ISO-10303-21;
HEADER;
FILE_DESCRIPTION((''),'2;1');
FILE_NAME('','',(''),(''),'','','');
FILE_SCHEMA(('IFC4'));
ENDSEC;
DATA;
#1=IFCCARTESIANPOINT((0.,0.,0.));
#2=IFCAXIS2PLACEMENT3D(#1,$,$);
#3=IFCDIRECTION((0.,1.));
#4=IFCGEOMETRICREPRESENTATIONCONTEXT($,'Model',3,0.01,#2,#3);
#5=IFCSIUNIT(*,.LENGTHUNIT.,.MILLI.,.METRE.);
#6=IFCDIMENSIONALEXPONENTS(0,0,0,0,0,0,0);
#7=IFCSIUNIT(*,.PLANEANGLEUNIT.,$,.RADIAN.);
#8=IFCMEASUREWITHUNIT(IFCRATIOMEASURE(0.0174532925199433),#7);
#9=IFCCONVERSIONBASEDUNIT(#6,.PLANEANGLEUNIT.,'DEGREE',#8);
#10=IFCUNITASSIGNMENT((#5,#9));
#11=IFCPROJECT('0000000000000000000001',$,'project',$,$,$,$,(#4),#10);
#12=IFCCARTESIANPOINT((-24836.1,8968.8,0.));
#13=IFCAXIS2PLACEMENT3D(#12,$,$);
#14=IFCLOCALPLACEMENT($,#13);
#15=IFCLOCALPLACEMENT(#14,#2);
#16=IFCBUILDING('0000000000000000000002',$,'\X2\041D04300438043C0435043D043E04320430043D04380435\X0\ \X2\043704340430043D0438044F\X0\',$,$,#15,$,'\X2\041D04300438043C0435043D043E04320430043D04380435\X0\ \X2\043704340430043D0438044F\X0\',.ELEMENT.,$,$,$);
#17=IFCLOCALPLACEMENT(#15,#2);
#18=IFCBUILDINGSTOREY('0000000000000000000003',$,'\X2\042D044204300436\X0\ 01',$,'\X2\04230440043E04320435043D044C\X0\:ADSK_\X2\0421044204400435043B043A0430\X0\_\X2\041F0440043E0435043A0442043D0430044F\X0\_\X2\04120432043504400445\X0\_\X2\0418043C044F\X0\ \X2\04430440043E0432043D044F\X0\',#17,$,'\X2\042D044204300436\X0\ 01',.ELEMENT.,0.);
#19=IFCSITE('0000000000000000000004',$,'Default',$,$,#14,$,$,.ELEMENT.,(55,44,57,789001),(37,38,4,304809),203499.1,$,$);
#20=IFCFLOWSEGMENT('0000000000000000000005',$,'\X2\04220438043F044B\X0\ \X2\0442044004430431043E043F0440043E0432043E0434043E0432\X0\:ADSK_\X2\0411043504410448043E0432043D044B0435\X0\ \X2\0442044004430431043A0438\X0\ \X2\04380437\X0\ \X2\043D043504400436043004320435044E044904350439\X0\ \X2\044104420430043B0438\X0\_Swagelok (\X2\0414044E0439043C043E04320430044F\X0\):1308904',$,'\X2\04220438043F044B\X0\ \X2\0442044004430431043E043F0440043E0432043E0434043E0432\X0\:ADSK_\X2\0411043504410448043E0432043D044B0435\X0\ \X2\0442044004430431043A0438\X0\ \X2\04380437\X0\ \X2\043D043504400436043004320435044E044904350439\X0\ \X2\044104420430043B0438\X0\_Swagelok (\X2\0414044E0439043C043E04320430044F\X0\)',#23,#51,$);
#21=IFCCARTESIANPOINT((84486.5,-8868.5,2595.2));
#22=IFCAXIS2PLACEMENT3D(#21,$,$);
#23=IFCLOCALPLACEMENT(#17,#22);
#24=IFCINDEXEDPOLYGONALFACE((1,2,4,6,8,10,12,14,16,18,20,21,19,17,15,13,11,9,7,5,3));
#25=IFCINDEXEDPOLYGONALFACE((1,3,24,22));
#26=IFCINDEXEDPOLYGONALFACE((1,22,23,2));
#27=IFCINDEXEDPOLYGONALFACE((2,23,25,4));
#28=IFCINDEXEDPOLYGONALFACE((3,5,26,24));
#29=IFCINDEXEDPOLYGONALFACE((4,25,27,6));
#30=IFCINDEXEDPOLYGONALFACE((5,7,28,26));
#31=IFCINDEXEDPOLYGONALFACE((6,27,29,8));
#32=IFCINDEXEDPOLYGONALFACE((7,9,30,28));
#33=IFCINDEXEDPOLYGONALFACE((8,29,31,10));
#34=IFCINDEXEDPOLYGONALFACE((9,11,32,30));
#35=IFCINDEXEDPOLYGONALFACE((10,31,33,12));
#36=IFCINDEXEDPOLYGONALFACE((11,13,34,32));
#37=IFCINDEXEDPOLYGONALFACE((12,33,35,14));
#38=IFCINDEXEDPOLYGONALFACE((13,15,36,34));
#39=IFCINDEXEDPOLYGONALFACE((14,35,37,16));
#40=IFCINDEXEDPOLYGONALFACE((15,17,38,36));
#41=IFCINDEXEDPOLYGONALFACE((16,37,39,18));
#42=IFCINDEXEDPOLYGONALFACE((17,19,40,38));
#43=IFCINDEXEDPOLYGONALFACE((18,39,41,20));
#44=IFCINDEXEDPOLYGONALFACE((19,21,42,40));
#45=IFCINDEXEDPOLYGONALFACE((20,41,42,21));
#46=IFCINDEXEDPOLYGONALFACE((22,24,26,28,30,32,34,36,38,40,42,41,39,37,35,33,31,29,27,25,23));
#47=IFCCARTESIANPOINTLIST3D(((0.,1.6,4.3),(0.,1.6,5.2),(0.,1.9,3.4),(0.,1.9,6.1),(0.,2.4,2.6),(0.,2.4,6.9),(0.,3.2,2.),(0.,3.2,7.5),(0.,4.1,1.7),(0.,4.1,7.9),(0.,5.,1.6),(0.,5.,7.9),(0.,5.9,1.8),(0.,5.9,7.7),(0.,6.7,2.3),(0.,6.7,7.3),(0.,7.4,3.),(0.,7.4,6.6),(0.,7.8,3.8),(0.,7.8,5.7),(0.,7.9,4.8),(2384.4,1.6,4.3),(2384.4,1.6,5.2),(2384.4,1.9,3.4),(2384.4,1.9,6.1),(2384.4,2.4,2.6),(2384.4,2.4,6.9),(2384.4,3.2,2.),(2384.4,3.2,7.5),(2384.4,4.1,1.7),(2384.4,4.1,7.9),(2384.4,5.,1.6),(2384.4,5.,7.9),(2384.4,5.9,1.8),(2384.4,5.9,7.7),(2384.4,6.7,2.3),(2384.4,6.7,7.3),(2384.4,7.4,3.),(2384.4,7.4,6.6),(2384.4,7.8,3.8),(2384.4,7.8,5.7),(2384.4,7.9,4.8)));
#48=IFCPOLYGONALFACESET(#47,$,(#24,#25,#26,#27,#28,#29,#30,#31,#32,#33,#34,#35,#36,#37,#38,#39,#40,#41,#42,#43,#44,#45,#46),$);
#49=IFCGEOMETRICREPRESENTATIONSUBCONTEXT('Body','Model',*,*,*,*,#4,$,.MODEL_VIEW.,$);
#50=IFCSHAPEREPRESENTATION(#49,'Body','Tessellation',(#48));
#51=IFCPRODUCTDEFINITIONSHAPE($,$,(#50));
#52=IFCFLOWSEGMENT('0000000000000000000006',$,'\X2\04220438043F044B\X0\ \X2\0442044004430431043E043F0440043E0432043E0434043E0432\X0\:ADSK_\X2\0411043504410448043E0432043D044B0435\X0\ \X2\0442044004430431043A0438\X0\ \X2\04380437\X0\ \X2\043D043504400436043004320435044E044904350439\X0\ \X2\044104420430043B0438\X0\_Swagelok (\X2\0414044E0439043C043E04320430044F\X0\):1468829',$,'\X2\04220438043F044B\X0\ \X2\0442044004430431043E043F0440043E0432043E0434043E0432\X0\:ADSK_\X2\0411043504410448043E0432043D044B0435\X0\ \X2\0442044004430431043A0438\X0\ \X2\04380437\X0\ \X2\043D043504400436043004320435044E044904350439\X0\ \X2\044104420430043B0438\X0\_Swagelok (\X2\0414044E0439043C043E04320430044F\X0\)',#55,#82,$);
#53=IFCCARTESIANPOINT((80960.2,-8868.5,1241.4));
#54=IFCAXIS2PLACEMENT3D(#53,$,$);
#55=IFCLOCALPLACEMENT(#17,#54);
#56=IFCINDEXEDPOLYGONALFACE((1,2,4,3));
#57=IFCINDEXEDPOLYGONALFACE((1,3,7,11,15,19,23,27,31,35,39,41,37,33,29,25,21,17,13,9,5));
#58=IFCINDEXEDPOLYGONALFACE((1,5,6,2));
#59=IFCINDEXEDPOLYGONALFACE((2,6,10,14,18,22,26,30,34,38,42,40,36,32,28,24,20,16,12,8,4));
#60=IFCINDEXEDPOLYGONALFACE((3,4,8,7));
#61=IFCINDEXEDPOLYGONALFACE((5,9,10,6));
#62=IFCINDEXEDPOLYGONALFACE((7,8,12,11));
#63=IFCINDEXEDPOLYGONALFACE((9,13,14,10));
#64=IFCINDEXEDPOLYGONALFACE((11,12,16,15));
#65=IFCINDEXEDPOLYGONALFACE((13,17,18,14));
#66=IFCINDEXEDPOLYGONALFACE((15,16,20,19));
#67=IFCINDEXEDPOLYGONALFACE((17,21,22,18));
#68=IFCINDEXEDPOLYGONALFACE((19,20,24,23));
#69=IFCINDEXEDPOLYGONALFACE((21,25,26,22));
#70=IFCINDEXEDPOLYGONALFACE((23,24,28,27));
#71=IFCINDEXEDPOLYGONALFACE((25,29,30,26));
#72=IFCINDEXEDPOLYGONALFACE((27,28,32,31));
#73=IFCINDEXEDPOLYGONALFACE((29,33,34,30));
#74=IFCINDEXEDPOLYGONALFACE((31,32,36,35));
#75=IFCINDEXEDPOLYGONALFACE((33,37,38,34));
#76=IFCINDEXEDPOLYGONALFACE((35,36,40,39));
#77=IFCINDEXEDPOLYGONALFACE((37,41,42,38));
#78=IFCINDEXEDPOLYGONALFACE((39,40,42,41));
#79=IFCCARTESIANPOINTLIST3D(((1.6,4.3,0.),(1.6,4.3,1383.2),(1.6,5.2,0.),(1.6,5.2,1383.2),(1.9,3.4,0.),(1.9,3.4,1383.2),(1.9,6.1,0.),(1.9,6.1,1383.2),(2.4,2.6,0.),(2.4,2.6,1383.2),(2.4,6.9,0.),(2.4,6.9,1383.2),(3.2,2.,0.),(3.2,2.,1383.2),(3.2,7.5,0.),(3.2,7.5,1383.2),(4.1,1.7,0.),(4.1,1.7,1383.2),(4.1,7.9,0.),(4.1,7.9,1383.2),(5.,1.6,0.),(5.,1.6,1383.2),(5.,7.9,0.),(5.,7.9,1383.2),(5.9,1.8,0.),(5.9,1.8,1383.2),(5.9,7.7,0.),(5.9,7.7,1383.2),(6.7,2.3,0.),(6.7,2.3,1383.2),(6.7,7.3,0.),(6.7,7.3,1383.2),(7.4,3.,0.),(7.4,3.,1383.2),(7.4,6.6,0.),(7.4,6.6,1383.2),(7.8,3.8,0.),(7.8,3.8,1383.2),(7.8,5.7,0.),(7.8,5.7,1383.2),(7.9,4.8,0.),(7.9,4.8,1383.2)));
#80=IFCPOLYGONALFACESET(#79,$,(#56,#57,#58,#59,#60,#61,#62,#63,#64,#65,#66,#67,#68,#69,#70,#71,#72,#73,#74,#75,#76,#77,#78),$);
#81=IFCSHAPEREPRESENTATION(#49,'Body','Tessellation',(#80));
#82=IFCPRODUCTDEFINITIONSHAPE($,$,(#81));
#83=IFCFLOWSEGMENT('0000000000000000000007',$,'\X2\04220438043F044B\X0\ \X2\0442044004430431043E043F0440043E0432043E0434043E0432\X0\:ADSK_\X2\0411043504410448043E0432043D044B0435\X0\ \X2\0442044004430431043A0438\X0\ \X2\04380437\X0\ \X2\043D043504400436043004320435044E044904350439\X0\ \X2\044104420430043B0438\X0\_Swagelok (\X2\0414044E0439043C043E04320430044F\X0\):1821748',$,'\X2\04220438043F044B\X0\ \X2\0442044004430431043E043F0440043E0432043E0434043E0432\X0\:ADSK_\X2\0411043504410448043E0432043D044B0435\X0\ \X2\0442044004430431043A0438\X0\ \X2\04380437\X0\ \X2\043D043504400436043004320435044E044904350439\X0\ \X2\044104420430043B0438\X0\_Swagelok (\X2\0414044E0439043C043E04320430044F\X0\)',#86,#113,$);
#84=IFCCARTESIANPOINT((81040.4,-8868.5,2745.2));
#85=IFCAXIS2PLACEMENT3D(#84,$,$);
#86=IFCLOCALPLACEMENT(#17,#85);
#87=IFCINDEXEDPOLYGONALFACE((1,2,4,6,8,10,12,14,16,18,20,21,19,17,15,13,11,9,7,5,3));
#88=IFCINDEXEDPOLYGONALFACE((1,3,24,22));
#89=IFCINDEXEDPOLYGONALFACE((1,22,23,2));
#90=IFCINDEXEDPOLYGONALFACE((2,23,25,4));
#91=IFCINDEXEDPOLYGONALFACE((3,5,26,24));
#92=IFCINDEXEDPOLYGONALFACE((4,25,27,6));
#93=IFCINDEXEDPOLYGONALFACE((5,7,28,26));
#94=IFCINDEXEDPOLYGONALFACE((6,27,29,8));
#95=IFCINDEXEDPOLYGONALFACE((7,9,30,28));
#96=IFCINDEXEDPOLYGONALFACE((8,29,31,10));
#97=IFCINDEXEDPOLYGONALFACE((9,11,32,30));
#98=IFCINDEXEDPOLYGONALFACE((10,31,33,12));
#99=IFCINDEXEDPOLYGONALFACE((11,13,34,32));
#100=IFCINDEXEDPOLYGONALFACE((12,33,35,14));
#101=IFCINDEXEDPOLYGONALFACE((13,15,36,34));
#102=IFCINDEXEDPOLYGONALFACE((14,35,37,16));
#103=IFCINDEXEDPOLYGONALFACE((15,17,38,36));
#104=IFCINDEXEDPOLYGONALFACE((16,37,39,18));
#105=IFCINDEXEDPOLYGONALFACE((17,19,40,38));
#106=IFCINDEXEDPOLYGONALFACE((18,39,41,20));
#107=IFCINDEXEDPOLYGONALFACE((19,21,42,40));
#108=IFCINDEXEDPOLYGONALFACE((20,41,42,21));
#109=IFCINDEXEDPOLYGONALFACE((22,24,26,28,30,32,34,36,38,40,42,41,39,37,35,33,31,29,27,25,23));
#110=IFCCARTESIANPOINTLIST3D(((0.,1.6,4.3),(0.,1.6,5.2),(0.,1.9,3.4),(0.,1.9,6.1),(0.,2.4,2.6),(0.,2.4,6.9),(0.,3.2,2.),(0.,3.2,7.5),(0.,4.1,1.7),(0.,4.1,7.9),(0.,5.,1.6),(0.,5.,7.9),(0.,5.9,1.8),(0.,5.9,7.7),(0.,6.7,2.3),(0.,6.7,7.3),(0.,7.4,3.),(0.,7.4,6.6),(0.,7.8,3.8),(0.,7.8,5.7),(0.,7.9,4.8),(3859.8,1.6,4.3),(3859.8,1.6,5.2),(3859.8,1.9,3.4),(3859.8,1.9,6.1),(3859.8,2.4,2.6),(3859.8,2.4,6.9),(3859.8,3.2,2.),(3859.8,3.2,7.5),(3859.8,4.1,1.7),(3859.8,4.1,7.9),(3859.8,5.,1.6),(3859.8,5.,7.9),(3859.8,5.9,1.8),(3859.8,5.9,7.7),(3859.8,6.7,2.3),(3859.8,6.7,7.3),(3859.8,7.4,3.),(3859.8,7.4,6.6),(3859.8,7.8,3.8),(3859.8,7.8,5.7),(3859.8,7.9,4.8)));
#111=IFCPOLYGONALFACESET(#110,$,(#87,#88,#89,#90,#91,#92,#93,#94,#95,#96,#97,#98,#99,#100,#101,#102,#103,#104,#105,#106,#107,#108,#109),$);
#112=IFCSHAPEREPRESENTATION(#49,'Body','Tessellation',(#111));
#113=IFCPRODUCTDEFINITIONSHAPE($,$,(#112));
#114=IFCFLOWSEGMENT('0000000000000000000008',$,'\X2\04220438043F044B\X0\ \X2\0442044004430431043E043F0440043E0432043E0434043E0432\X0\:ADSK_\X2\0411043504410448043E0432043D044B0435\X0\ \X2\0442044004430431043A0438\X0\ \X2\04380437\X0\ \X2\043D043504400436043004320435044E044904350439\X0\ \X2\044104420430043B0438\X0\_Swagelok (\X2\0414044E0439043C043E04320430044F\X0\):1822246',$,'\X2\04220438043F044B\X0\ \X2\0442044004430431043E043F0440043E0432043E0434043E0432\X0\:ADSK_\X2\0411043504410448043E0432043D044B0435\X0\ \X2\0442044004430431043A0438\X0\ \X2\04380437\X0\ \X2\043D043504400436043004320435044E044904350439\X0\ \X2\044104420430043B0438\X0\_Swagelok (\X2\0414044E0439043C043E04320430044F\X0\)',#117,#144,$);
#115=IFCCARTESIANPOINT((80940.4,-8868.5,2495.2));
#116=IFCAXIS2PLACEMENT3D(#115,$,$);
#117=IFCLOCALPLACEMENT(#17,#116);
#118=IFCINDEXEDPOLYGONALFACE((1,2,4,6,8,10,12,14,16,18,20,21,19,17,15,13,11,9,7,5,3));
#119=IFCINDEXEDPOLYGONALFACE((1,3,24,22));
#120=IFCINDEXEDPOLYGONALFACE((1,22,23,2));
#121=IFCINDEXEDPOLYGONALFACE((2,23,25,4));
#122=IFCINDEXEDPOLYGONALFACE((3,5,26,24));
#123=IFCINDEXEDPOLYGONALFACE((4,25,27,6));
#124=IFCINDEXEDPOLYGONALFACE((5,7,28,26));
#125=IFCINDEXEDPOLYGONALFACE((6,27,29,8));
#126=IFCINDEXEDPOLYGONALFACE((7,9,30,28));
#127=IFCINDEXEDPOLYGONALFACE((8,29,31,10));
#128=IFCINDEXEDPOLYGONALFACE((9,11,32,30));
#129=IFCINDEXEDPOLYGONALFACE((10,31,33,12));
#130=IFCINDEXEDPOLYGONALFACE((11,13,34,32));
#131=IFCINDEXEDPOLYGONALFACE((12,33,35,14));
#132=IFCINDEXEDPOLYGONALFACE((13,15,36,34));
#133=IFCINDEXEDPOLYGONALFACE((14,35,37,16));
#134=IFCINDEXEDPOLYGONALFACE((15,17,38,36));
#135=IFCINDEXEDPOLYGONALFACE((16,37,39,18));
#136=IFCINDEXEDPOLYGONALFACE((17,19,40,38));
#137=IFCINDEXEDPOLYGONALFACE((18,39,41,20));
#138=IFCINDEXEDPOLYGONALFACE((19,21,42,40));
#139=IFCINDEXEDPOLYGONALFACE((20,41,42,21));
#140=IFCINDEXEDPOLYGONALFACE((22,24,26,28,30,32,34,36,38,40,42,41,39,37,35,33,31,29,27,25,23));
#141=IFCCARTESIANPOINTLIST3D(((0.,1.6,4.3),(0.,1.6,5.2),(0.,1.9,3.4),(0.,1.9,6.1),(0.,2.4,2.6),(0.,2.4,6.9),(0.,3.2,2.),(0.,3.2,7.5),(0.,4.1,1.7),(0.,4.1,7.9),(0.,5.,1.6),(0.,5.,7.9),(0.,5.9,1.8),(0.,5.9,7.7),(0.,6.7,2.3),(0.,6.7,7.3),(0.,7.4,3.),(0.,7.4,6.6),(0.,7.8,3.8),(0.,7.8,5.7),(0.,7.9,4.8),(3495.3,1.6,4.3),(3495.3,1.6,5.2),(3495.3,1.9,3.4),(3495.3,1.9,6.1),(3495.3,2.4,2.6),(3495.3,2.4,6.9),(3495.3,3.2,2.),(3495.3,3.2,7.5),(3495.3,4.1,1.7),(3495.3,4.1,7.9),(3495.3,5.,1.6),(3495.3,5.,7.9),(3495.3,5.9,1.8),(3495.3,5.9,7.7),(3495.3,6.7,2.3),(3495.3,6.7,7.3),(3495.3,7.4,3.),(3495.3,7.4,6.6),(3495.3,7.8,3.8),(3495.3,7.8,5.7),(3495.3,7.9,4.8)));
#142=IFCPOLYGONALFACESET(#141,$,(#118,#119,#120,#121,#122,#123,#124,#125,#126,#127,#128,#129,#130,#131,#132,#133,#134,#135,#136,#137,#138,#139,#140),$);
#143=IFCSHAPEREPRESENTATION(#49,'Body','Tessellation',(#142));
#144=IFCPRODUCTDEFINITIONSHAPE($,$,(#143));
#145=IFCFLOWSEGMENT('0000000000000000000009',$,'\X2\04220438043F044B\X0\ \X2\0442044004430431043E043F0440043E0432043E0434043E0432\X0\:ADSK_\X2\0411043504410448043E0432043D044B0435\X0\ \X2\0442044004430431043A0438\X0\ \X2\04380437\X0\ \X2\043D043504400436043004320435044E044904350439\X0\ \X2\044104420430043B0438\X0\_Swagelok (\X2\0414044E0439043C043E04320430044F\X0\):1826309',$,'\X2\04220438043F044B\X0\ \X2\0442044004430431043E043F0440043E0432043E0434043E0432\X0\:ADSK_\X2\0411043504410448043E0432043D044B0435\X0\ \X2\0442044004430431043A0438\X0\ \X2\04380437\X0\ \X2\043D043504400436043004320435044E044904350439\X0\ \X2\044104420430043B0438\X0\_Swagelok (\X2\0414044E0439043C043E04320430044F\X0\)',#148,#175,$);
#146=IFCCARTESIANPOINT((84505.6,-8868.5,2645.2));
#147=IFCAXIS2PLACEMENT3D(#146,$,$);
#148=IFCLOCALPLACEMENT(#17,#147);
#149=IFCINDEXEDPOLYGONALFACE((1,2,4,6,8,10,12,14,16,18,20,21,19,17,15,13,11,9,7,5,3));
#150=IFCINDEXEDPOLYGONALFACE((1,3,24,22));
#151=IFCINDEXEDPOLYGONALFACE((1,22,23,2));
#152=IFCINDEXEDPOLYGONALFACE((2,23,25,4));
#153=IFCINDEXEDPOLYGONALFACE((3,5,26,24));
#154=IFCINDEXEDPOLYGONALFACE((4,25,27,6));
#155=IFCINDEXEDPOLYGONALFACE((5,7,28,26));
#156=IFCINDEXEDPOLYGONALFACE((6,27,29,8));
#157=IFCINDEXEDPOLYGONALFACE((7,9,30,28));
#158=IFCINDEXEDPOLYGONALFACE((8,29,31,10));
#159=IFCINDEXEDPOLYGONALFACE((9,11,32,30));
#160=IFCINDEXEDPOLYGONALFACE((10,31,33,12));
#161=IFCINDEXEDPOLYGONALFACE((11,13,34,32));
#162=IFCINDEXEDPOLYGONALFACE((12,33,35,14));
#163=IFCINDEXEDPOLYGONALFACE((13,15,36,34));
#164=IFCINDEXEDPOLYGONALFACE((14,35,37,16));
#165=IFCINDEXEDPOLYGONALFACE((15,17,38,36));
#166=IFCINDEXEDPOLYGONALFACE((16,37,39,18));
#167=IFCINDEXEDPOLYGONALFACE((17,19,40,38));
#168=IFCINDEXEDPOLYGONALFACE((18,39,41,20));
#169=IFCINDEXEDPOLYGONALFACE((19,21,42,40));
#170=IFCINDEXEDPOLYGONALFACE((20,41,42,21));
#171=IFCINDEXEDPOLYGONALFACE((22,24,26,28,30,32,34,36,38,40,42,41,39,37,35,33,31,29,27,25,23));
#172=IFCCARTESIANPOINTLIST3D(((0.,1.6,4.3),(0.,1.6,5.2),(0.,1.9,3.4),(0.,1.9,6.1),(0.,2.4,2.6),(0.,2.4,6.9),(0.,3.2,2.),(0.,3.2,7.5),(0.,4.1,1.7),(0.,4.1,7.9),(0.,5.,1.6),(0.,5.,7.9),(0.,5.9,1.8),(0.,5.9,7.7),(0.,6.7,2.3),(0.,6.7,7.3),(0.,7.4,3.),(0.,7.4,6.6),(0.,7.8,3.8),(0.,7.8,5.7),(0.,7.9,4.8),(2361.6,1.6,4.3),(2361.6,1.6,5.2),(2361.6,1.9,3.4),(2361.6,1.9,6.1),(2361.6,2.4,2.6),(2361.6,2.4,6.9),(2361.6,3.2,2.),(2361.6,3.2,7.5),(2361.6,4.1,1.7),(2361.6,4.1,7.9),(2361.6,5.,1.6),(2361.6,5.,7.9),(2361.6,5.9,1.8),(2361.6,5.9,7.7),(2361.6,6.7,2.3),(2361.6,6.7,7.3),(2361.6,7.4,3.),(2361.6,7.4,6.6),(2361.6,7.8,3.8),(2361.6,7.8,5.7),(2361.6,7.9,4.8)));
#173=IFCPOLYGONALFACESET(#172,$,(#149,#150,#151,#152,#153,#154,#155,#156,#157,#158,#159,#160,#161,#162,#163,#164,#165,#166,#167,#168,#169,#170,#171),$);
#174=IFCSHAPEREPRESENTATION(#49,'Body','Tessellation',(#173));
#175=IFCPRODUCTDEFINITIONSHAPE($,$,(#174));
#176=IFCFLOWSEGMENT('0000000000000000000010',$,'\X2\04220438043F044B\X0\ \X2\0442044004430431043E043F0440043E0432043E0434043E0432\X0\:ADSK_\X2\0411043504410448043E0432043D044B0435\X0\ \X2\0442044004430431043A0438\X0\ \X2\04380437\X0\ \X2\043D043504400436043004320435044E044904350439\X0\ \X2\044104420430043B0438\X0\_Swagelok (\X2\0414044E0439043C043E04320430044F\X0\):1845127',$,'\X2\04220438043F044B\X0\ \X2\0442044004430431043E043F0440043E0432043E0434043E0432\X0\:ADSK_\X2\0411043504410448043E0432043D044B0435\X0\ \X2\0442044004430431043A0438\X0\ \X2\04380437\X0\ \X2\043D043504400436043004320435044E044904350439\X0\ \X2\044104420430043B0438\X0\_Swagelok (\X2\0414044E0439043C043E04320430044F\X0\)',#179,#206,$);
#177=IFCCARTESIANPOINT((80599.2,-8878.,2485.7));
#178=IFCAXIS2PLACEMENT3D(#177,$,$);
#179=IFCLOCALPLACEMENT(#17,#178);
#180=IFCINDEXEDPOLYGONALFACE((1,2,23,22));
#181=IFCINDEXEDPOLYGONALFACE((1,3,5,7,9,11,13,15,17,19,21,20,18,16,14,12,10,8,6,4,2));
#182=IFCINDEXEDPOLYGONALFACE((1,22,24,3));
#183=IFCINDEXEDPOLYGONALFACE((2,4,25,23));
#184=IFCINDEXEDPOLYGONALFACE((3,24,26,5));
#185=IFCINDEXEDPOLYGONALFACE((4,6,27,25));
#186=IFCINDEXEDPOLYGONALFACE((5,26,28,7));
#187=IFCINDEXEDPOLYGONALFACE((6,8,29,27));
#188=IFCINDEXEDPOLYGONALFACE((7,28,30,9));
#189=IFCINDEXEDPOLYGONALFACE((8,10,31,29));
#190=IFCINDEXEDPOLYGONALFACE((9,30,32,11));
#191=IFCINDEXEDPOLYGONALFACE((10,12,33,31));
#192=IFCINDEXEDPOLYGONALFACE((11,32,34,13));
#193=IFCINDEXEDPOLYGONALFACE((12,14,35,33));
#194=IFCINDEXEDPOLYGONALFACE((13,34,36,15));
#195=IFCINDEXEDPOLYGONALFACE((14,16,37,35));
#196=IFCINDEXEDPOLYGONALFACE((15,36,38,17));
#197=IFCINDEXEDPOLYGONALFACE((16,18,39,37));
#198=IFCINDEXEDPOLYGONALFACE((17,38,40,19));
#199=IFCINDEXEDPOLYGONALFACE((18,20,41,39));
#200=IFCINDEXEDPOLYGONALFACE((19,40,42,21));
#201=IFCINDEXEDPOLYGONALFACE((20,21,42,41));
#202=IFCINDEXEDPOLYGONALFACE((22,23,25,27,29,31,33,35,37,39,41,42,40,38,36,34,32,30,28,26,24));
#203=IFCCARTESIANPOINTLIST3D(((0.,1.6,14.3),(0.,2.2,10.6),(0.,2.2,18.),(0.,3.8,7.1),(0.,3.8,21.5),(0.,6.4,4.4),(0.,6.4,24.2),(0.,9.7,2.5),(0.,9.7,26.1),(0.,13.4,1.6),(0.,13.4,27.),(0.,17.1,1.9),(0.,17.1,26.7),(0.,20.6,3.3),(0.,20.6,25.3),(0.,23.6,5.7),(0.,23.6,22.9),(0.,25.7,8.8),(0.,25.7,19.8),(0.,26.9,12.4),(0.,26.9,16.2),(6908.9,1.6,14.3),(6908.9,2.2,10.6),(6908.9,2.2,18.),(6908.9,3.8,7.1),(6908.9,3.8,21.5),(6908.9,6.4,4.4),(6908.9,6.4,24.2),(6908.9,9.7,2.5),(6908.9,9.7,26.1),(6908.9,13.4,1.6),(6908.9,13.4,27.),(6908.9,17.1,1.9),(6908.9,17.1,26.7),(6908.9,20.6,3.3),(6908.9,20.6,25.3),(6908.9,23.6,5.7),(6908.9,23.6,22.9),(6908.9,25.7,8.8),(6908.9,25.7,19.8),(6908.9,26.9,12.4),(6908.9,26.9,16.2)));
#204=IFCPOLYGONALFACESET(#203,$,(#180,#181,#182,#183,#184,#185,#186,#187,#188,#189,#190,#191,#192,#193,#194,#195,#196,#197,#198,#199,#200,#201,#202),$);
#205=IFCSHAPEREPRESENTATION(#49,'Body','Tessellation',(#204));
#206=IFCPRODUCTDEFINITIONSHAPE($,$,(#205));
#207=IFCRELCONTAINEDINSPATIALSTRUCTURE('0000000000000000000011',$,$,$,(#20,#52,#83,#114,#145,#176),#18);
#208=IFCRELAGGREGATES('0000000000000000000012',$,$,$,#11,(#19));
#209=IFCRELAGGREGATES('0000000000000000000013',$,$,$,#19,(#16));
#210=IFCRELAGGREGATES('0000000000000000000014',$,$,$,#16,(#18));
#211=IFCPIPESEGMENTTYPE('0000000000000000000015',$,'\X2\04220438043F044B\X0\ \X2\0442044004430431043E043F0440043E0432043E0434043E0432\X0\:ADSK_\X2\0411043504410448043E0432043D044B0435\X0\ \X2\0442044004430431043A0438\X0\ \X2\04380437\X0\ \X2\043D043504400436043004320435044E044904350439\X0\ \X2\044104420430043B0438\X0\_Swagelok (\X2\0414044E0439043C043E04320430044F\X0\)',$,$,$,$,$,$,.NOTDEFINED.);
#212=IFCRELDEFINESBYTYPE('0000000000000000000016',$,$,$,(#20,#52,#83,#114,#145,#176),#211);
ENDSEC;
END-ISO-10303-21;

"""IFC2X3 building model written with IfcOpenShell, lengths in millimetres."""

from ifc_helpers import new_model, entity, si_unit, converted_unit, direction, frame, origin, origin_2d_with_axis, place, context, subcontext, project, spatial, circle, extrude, type_object, element, save


model = new_model("IFC2X3")

# Units and contexts
model_context = context("Model", 3, precision=0.01, world=origin(), true_north=direction((0.0, 1.0)))
body_context = subcontext(model_context, "Body", "Model", "MODEL_VIEW")
ifc_project = project(units=[si_unit("LENGTHUNIT", "METRE", prefix="MILLI"), converted_unit("PLANEANGLEUNIT", "DEGREE", entity("IfcRatioMeasure", 0.0174532925199433), si_unit("PLANEANGLEUNIT", "RADIAN"), dimensions=[0, 0, 0, 0, 0, 0, 0])], contexts=[model_context])

# Site, building, storey
site_placement = place(None, frame((-24836.1, 8968.8, 0.0)))
site = spatial("IfcSite", under=ifc_project, at=site_placement, Name="Default", CompositionType="ELEMENT", RefLatitude=(55, 44, 57, 789001), RefLongitude=(37, 38, 4, 304809), RefElevation=203499.1)
building_placement = place(site_placement, origin())
building = spatial("IfcBuilding", under=site, at=building_placement, Name="Наименование здания", LongName="Наименование здания", CompositionType="ELEMENT")
storey_placement = place(building_placement, origin())
storey = spatial("IfcBuildingStorey", under=building, at=storey_placement, Name="Этаж 01", ObjectType="Уровень:ADSK_Стрелка_Проектная_Вверх_Имя уровня", LongName="Этаж 01", CompositionType="ELEMENT", Elevation=0.0)

# Flow segments
pipe_segment_type_1 = type_object("IfcPipeSegmentType", Name="Типы трубопроводов:ADSK_Бесшовные трубки из нержавеющей стали_Swagelok (Дюймовая)", PredefinedType="NOTDEFINED")
flow_segment_1_placement = place(storey_placement, frame((84486.5, -8868.5, 2595.2)))
element("IfcFlowSegment", 1, at=flow_segment_1_placement, inside=storey, type_object=pipe_segment_type_1, Name="Типы трубопроводов:ADSK_Бесшовные трубки из нержавеющей стали_Swagelok (Дюймовая):1308904", ObjectType="Типы трубопроводов:ADSK_Бесшовные трубки из нержавеющей стали_Swagelok (Дюймовая)", context=body_context, shape_type="SweptSolid", body=[
    extrude(circle(Radius=3.2, at=origin_2d_with_axis()), frame((0.0, 4.8, 4.8), z_axis=(1.0, 0.0, 0.0), x_axis=(0.0, 1.0, 0.0)), (0.0, 0.0, 1.0), 2384.4),
])
flow_segment_2_placement = place(storey_placement, frame((80960.2, -8868.5, 1241.4)))
element("IfcFlowSegment", 2, at=flow_segment_2_placement, inside=storey, type_object=pipe_segment_type_1, Name="Типы трубопроводов:ADSK_Бесшовные трубки из нержавеющей стали_Swagelok (Дюймовая):1468829", ObjectType="Типы трубопроводов:ADSK_Бесшовные трубки из нержавеющей стали_Swagelok (Дюймовая)", context=body_context, shape_type="SweptSolid", body=[
    extrude(circle(Radius=3.2, at=origin_2d_with_axis()), frame((4.8, 4.8, 0.0)), (0.0, 0.0, 1.0), 1383.2),
])
flow_segment_3_placement = place(storey_placement, frame((81040.4, -8868.5, 2745.2)))
element("IfcFlowSegment", 3, at=flow_segment_3_placement, inside=storey, type_object=pipe_segment_type_1, Name="Типы трубопроводов:ADSK_Бесшовные трубки из нержавеющей стали_Swagelok (Дюймовая):1821748", ObjectType="Типы трубопроводов:ADSK_Бесшовные трубки из нержавеющей стали_Swagelok (Дюймовая)", context=body_context, shape_type="SweptSolid", body=[
    extrude(circle(Radius=3.2, at=origin_2d_with_axis()), frame((0.0, 4.8, 4.8), z_axis=(1.0, 0.0, 0.0), x_axis=(0.0, 1.0, 0.0)), (0.0, 0.0, 1.0), 3859.8),
])
flow_segment_4_placement = place(storey_placement, frame((80940.4, -8868.5, 2495.2)))
element("IfcFlowSegment", 4, at=flow_segment_4_placement, inside=storey, type_object=pipe_segment_type_1, Name="Типы трубопроводов:ADSK_Бесшовные трубки из нержавеющей стали_Swagelok (Дюймовая):1822246", ObjectType="Типы трубопроводов:ADSK_Бесшовные трубки из нержавеющей стали_Swagelok (Дюймовая)", context=body_context, shape_type="SweptSolid", body=[
    extrude(circle(Radius=3.2, at=origin_2d_with_axis()), frame((0.0, 4.8, 4.8), z_axis=(1.0, 0.0, 0.0), x_axis=(0.0, 1.0, 0.0)), (0.0, 0.0, 1.0), 3495.3),
])
flow_segment_5_placement = place(storey_placement, frame((84505.6, -8868.5, 2645.2)))
element("IfcFlowSegment", 5, at=flow_segment_5_placement, inside=storey, type_object=pipe_segment_type_1, Name="Типы трубопроводов:ADSK_Бесшовные трубки из нержавеющей стали_Swagelok (Дюймовая):1826309", ObjectType="Типы трубопроводов:ADSK_Бесшовные трубки из нержавеющей стали_Swagelok (Дюймовая)", context=body_context, shape_type="SweptSolid", body=[
    extrude(circle(Radius=3.2, at=origin_2d_with_axis()), frame((0.0, 4.8, 4.8), z_axis=(1.0, 0.0, 0.0), x_axis=(0.0, 1.0, 0.0)), (0.0, 0.0, 1.0), 2361.6),
])
flow_segment_6_placement = place(storey_placement, frame((80599.2, -8878.0, 2485.7)))
element("IfcFlowSegment", 6, at=flow_segment_6_placement, inside=storey, type_object=pipe_segment_type_1, Name="Типы трубопроводов:ADSK_Бесшовные трубки из нержавеющей стали_Swagelok (Дюймовая):1845127", ObjectType="Типы трубопроводов:ADSK_Бесшовные трубки из нержавеющей стали_Swagelok (Дюймовая)", context=body_context, shape_type="SweptSolid", body=[
    extrude(circle(Radius=12.7, at=origin_2d_with_axis()), frame((0.0, 14.3, 14.3), z_axis=(1.0, 0.0, 0.0), x_axis=(0.0, -1.0, 0.0)), (0.0, 0.0, 1.0), 6908.9),
])

save(model, "model.ifc")
